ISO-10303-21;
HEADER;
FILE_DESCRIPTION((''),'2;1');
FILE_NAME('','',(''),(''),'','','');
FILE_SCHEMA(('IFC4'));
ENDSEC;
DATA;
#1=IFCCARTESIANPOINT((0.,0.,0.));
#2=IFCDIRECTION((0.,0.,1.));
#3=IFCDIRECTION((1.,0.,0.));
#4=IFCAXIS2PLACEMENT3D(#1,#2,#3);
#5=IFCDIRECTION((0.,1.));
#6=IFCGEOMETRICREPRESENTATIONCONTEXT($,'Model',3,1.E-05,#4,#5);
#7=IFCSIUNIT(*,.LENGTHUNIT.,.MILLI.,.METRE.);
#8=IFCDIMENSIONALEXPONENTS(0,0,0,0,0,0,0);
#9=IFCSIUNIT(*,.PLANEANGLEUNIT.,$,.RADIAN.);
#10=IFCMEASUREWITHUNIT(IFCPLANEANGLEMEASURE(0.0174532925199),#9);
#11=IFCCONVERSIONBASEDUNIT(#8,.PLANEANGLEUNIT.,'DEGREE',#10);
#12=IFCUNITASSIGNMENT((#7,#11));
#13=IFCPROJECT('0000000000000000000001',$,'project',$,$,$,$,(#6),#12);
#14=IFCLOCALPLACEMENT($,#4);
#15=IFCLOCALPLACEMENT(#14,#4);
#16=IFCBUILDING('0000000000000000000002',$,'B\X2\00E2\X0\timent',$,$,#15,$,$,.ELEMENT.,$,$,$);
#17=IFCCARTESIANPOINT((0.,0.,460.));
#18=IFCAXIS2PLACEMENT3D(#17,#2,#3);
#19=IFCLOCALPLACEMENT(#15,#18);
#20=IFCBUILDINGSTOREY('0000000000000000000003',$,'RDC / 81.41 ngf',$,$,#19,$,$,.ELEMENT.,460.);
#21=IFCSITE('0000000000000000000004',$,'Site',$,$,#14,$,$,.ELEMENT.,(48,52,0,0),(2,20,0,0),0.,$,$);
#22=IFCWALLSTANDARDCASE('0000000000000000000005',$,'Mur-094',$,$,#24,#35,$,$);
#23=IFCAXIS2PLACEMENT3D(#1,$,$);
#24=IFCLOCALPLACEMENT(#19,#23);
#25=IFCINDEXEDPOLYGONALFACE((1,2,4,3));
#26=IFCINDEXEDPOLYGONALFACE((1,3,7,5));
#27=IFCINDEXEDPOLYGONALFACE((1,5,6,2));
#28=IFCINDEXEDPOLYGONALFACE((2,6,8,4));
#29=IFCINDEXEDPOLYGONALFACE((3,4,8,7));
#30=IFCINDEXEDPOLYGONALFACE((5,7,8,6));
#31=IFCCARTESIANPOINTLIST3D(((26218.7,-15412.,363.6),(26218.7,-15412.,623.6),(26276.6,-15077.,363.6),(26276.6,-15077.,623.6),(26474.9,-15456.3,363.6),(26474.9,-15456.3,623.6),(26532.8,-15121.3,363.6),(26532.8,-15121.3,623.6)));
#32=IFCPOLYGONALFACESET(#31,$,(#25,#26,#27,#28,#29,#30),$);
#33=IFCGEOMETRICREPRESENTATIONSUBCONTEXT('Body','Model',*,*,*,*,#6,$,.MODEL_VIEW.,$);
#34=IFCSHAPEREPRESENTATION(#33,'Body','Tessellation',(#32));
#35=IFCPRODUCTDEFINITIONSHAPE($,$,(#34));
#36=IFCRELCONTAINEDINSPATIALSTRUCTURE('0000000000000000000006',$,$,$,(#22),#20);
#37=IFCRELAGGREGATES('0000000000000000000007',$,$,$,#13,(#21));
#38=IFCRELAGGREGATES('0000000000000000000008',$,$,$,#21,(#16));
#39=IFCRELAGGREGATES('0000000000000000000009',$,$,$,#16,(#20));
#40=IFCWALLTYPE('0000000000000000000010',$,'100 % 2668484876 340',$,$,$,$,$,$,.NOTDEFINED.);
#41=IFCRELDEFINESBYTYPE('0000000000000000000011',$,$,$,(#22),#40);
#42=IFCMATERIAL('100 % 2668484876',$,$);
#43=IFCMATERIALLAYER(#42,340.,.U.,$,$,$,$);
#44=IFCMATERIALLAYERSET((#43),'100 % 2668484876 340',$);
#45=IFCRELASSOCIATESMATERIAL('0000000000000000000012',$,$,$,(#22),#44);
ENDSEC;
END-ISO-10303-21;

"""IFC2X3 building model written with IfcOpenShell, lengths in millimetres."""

from ifc_helpers import new_model, entity, si_unit, converted_unit, direction, frame, origin_with_axes, place, context, subcontext, project, spatial, polyline, outline, extrude, material, layer, layer_set, layer_usage, type_object, element, save


model = new_model("IFC2X3")

# Units and contexts
model_context = context("Model", 3, precision=1e-05, world=origin_with_axes(), true_north=direction((0.0, 1.0)))
body_context = subcontext(model_context, "Body", "Model", "MODEL_VIEW")
ifc_project = project(units=[si_unit("LENGTHUNIT", "METRE", prefix="MILLI"), converted_unit("PLANEANGLEUNIT", "DEGREE", entity("IfcPlaneAngleMeasure", 0.0174532925199), si_unit("PLANEANGLEUNIT", "RADIAN"), dimensions=[0, 0, 0, 0, 0, 0, 0])], contexts=[model_context])

# Site, building, storey
site_placement = place(None, origin_with_axes())
site = spatial("IfcSite", under=ifc_project, at=site_placement, Name="Site", CompositionType="ELEMENT", RefLatitude=(48, 52, 0, 0), RefLongitude=(2, 20, 0, 0), RefElevation=0.0)
building_placement = place(site_placement, origin_with_axes())
building = spatial("IfcBuilding", under=site, at=building_placement, Name="Bâtiment", CompositionType="ELEMENT")
storey_placement = place(building_placement, frame((0.0, 0.0, 460.0), z_axis=(0.0, 0.0, 1.0), x_axis=(1.0, 0.0, 0.0)))
storey = spatial("IfcBuildingStorey", under=building, at=storey_placement, Name="RDC / 81.41 ngf", CompositionType="ELEMENT", Elevation=460.0)

# Shared definitions
ifc_material_1 = material(Name="100 % 2668484876")

# Wall
ifc_layer_1 = layer(ifc_material_1, 340.0, ventilated="UNKNOWN")
ifc_layer_set_1 = layer_set([ifc_layer_1], Name="100 % 2668484876 340")
ifc_layer_usage_1 = layer_usage(ifc_layer_set_1, "AXIS2", "NEGATIVE", 340.0)
wall_type_1 = type_object("IfcWallType", Name="100 % 2668484876 340", PredefinedType="NOTDEFINED")
wall_1_placement = place(storey_placement, frame((26218.7, -15412.0, 363.6), z_axis=(0.0, 0.0, 1.0), x_axis=(0.985365, -0.17046, 0.0)))
element("IfcWallStandardCase", 1, at=wall_1_placement, inside=storey, type_object=wall_type_1, material=ifc_layer_usage_1, Name="Mur-094", context=body_context, shape_type="SweptSolid", body=[
    extrude(outline(polyline([(0.0, 0.0), (260.0, 0.0), (260.0, 340.0), (0.0, 340.0), (0.0, 0.0)])), origin_with_axes(), (0.0, 0.0, 1.0), 260.0),
])

save(model, "model.ifc")
